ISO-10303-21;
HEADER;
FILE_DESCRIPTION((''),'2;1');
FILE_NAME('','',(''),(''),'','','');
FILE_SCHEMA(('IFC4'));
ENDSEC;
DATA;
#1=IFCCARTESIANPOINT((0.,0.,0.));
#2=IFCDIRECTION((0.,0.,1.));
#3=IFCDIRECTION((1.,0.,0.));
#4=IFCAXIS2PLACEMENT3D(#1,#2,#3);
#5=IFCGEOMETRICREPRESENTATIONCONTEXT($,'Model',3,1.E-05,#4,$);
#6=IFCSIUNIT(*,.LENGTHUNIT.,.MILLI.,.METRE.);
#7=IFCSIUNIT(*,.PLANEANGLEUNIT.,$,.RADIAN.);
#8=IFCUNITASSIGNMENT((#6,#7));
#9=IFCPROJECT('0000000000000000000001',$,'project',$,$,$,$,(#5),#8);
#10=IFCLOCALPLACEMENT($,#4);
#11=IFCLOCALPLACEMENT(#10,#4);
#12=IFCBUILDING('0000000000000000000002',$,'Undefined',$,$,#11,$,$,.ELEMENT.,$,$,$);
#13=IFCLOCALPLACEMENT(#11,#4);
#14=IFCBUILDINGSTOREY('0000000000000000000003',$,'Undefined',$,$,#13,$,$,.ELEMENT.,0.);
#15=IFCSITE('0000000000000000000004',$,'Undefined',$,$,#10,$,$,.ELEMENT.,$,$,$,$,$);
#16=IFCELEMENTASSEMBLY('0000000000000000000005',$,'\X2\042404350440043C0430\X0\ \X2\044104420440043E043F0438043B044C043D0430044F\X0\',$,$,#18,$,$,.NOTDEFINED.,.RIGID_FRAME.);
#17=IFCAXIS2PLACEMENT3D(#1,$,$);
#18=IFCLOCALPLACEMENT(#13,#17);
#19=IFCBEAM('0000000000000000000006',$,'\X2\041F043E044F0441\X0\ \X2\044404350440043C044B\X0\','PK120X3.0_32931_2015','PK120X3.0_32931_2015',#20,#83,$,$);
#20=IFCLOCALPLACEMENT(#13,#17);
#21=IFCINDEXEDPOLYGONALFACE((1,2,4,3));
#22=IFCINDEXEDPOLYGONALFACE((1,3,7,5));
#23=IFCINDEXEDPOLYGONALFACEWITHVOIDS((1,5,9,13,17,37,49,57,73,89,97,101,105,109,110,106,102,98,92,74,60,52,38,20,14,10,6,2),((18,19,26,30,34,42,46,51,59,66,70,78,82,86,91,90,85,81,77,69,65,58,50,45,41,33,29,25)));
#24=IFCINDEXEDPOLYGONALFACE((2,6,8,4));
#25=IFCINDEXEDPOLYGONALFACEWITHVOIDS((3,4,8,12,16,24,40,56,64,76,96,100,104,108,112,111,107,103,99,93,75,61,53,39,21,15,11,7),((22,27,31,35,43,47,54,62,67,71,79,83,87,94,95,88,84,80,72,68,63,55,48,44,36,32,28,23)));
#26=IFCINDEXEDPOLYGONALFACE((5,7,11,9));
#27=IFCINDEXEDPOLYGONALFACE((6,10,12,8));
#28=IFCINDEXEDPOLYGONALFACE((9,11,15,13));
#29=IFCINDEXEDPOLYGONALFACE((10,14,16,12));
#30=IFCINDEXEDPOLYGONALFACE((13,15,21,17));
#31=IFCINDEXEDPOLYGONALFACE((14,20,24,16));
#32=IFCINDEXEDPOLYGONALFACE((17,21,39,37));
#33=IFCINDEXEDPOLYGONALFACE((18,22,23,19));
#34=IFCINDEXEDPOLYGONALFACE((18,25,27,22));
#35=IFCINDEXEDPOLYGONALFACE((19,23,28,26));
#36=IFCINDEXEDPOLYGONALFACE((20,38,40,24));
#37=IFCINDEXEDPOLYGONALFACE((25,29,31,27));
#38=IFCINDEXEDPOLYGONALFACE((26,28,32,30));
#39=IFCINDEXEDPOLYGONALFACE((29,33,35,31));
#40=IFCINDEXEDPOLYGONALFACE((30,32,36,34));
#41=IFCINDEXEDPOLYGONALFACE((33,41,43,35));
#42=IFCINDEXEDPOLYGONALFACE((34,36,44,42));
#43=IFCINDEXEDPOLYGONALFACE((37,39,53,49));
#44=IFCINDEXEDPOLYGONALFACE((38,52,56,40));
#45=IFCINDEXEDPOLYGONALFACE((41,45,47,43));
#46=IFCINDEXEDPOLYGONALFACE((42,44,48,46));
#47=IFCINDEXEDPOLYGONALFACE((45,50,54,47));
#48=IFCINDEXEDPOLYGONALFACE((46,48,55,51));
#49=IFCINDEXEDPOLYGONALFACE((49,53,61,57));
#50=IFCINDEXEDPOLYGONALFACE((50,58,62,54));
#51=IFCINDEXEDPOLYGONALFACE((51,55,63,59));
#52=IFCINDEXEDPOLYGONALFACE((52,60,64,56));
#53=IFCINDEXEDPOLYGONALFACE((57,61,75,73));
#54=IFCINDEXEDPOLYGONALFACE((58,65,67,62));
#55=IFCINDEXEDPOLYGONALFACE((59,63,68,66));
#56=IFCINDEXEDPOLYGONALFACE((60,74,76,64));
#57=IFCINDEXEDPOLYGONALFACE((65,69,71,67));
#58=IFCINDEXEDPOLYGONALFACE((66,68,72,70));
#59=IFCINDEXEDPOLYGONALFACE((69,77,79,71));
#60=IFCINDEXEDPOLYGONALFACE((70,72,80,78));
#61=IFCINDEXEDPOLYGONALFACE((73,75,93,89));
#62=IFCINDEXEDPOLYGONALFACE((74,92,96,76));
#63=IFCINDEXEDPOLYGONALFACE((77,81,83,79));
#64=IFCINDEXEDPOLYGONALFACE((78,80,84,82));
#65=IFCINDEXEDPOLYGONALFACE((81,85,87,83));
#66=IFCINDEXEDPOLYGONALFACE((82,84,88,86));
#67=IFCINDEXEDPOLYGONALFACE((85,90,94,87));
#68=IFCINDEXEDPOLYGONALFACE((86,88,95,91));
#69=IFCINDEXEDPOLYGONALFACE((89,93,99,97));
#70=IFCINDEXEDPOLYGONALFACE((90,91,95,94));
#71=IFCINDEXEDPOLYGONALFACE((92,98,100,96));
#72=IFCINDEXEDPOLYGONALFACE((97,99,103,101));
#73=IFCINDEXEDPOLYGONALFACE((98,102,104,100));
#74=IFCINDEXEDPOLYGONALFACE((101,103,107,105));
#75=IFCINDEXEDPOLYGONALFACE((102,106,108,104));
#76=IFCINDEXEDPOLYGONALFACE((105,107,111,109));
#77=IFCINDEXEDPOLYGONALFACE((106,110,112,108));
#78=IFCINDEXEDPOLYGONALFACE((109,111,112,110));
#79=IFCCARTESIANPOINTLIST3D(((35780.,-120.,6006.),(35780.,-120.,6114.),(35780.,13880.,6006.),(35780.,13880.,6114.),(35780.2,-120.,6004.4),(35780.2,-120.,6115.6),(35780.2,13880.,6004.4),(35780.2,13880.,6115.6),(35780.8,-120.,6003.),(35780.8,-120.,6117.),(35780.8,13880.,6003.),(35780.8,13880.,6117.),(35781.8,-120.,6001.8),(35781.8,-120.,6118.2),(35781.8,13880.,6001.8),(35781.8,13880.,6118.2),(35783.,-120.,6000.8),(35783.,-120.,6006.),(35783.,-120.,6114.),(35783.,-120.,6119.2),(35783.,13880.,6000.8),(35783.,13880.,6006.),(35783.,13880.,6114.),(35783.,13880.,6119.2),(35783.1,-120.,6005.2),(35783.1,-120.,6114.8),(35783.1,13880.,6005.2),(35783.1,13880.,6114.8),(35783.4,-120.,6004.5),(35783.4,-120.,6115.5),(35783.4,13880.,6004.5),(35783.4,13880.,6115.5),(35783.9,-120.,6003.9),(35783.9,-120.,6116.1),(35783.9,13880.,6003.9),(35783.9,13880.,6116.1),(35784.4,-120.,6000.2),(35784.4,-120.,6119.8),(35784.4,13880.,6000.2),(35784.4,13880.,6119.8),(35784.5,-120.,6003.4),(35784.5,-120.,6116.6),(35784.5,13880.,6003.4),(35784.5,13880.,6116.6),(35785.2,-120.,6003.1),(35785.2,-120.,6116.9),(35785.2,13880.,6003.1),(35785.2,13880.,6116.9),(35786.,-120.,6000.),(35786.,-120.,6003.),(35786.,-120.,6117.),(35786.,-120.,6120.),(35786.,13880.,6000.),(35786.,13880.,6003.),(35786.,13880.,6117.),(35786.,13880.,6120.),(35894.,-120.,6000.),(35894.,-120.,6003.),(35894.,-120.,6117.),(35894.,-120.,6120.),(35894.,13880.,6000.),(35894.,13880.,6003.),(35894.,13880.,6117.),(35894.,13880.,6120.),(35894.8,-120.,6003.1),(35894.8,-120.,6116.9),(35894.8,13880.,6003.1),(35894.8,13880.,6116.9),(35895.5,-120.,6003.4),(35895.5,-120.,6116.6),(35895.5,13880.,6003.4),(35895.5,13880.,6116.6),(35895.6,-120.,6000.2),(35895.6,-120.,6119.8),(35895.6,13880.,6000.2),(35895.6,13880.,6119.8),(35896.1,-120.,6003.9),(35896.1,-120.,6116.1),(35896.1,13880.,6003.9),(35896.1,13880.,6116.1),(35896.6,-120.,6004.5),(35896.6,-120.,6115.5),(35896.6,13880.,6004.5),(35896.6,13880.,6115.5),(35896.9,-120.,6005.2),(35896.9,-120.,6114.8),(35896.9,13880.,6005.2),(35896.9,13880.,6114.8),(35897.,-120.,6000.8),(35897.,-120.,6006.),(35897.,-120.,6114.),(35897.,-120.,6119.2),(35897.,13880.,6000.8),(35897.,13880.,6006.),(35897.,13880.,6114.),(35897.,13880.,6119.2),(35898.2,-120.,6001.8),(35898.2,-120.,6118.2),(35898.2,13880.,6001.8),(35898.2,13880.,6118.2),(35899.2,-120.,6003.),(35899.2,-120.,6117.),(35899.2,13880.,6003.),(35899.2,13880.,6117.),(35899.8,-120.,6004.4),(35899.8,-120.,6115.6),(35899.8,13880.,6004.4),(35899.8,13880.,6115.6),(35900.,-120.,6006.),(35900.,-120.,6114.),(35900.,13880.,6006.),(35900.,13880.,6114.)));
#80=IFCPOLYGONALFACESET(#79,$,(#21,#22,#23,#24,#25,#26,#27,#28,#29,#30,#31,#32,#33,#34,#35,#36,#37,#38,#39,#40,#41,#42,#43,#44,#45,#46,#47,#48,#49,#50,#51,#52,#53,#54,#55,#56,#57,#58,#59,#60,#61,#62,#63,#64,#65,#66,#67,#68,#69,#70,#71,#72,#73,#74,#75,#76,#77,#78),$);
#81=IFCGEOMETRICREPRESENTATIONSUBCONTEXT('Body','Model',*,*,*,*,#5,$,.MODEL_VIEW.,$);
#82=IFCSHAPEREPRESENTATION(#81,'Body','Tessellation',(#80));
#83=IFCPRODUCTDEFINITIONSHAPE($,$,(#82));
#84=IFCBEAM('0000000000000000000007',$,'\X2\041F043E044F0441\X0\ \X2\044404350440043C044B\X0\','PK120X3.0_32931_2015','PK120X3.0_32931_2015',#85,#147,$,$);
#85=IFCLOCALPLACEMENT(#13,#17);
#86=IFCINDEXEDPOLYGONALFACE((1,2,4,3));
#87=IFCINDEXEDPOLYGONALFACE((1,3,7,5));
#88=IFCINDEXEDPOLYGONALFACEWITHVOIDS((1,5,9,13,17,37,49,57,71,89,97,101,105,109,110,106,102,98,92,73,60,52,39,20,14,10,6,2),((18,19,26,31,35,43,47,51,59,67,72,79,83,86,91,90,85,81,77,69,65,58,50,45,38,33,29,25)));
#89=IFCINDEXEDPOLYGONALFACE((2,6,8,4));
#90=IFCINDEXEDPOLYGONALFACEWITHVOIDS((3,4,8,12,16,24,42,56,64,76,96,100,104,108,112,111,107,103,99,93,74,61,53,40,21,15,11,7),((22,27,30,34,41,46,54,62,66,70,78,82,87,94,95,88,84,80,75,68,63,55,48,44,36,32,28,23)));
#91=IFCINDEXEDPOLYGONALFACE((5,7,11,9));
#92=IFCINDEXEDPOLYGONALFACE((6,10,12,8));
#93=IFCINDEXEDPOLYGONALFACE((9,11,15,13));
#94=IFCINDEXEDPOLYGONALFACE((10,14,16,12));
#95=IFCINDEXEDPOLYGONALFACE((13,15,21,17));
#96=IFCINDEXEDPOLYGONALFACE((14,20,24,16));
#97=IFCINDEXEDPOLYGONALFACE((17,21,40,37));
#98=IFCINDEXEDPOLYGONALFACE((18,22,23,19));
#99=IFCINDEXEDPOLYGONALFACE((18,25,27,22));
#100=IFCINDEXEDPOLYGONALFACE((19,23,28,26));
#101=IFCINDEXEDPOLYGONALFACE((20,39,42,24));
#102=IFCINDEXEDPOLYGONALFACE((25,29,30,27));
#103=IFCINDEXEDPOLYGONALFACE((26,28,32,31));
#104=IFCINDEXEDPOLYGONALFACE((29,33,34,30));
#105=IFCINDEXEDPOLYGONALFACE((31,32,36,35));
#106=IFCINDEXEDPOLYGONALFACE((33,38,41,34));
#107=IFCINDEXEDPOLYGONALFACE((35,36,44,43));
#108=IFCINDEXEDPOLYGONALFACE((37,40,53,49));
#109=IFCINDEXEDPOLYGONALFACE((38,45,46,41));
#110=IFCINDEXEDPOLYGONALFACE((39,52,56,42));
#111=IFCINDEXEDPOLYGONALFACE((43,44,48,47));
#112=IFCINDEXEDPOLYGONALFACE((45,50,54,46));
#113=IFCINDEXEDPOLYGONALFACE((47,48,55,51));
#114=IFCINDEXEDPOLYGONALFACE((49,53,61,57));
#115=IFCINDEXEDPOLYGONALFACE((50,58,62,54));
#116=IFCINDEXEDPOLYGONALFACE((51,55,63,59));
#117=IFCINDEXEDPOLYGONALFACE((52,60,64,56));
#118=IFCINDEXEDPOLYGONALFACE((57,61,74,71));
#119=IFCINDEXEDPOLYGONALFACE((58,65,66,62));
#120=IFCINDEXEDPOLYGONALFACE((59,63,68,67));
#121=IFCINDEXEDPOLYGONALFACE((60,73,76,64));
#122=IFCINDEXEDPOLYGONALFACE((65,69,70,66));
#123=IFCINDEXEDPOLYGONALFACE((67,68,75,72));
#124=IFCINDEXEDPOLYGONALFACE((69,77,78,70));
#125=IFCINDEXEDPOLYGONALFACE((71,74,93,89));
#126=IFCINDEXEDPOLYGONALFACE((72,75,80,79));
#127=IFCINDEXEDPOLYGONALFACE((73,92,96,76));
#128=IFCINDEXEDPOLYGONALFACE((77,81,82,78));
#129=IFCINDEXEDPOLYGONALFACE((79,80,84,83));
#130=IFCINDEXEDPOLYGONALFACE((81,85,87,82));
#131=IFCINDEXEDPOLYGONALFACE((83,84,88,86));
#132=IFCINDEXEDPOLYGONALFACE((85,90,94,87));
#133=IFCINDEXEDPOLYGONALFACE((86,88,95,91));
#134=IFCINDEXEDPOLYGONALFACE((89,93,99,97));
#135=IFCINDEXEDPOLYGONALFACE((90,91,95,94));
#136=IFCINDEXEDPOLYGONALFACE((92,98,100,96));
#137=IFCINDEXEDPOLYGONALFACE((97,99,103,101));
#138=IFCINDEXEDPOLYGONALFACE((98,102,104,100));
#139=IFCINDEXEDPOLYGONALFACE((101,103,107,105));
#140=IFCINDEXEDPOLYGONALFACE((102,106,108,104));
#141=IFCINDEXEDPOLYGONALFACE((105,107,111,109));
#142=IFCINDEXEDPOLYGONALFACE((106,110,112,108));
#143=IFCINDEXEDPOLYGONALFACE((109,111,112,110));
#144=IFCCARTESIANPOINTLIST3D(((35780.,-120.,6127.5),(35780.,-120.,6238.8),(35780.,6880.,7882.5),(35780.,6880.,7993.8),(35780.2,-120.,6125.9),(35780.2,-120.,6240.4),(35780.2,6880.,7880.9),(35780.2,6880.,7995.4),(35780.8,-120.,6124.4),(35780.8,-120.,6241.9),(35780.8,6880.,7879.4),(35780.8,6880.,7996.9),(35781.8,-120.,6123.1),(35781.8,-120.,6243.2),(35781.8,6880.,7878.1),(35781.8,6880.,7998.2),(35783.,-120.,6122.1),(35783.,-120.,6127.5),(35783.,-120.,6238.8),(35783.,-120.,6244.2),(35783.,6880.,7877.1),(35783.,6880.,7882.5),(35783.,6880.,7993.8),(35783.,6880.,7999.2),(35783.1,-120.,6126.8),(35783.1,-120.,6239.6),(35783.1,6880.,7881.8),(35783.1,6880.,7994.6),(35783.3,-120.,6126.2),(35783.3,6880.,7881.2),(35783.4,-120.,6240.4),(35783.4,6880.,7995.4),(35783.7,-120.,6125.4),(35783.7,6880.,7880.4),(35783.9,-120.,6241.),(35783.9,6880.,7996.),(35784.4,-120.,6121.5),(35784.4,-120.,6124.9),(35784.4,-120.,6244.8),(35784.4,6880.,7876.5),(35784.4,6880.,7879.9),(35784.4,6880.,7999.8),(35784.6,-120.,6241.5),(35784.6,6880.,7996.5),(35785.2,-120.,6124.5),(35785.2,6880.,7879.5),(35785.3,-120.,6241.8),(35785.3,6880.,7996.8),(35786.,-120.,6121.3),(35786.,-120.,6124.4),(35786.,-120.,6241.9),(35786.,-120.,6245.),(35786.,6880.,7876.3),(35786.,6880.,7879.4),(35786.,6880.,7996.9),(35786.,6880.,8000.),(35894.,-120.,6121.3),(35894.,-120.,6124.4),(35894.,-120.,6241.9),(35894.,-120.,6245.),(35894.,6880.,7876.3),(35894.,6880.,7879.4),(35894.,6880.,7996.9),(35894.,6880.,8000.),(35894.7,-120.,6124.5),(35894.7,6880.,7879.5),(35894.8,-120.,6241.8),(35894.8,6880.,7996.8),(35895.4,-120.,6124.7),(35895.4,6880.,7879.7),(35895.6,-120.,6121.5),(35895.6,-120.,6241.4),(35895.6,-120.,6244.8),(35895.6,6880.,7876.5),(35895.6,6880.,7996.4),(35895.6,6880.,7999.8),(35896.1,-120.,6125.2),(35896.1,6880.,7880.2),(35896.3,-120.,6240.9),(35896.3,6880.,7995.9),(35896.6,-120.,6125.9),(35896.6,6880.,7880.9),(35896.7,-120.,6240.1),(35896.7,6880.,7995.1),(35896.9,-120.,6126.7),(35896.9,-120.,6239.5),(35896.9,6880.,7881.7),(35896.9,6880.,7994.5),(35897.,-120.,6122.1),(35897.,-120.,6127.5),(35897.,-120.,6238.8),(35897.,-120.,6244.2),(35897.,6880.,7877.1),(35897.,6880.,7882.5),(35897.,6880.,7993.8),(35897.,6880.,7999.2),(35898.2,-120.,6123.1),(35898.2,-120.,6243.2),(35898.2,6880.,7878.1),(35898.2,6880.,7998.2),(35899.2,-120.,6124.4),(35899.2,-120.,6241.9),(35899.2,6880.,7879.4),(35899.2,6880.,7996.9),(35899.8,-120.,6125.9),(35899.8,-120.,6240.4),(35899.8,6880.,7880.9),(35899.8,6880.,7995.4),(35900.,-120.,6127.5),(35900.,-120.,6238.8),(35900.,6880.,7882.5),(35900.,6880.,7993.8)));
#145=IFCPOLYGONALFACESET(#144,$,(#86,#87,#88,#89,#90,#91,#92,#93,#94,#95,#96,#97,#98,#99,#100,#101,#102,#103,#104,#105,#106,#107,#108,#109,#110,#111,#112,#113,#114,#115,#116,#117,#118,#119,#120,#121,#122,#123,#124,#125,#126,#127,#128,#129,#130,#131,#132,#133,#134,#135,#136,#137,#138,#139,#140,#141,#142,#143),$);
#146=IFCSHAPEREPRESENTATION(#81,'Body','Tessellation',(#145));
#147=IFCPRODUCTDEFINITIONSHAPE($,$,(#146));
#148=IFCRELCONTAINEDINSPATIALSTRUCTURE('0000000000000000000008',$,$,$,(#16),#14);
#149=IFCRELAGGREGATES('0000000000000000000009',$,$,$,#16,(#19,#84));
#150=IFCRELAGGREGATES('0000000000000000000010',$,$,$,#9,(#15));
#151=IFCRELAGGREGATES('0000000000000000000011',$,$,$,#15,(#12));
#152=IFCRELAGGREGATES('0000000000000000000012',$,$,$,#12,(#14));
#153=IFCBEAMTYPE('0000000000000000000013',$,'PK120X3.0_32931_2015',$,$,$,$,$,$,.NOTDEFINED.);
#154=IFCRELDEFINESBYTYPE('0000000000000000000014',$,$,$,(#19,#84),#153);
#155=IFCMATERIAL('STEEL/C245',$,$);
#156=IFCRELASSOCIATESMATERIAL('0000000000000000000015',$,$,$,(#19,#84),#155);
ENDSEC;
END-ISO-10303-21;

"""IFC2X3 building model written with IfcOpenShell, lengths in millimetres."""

from ifc_helpers import new_model, si_unit, frame, origin_with_axes, origin_2d_with_axis, place, context, subcontext, project, spatial, hollow_rectangle, extrude, clip, halfspace, material, type_object, element, aggregate, save


model = new_model("IFC2X3")

# Units and contexts
model_context = context("Model", 3, precision=1e-05, world=origin_with_axes())
body_context = subcontext(model_context, "Body", "Model", "MODEL_VIEW")
ifc_project = project(units=[si_unit("LENGTHUNIT", "METRE", prefix="MILLI"), si_unit("PLANEANGLEUNIT", "RADIAN")], contexts=[model_context])

# Site, building, storey
site_placement = place(None, origin_with_axes())
site = spatial("IfcSite", under=ifc_project, at=site_placement, Name="Undefined", CompositionType="ELEMENT")
building_placement = place(site_placement, origin_with_axes())
building = spatial("IfcBuilding", under=site, at=building_placement, Name="Undefined", CompositionType="ELEMENT")
storey_placement = place(building_placement, origin_with_axes())
storey = spatial("IfcBuildingStorey", under=building, at=storey_placement, Name="Undefined", CompositionType="ELEMENT", Elevation=0.0)

# Shared definitions
ifc_material = material(Name="STEEL/C245")

# Element assembly
assembly_1_placement = place(storey_placement, origin_with_axes())
assembly_1 = element("IfcElementAssembly", 1, at=assembly_1_placement, inside=storey, Name="Ферма стропильная", AssemblyPlace="NOTDEFINED", PredefinedType="RIGID_FRAME")

# Beams
beam_type_1 = type_object("IfcBeamType", Name="PK120X3.0_32931_2015", PredefinedType="NOTDEFINED")
beam_1_placement = place(assembly_1_placement, frame((35840.0, -120.0, 6060.0), z_axis=(0.0, 0.0, 1.0), x_axis=(0.0, 1.0, 0.0)))
beam_1 = element("IfcBeam", 2, at=beam_1_placement, type_object=beam_type_1, material=ifc_material, Name="Пояс фермы", Description="PK120X3.0_32931_2015", ObjectType="PK120X3.0_32931_2015", context=body_context, shape_type="SweptSolid", body=[
    extrude(hollow_rectangle(XDim=120.0, YDim=120.0, WallThickness=3.0, InnerFilletRadius=3.0, OuterFilletRadius=6.0, at=origin_2d_with_axis()), frame((14000.0, 0.0, 0.0), z_axis=(-1.0, 0.0, 0.0), x_axis=(0.0, -1.0, 0.0)), (0.0, 0.0, 1.0), 14000.0),
])
beam_2_placement = place(assembly_1_placement, frame((35840.0, -105.4, 6186.8), z_axis=(0.0, -0.243188, 0.969979), x_axis=(0.0, 0.969979, 0.243188)))
beam_2 = element("IfcBeam", 3, at=beam_2_placement, type_object=beam_type_1, material=ifc_material, Name="Пояс фермы", Description="PK120X3.0_32931_2015", ObjectType="PK120X3.0_32931_2015", context=body_context, shape_type="Clipping", body=[
    clip(clip(extrude(hollow_rectangle(XDim=120.0, YDim=120.0, WallThickness=3.0, InnerFilletRadius=3.0, OuterFilletRadius=6.0, at=origin_2d_with_axis()), frame((7232.0, 0.0, 0.0), z_axis=(-1.0, 0.0, 0.0), x_axis=(0.0, -1.0, 0.0)), (0.0, 0.0, 1.0), 7277.4), halfspace(frame((7216.6, 0.0, 60.0), z_axis=(0.969979, 0.0, -0.243188), x_axis=(0.0, -1.0, 0.0)), False)), halfspace(frame((0.0, 0.0, 60.0), z_axis=(0.969979, 0.0, -0.243188), x_axis=(0.0, -1.0, 0.0)), True)),
])
aggregate(assembly_1, [beam_1, beam_2])

save(model, "model.ifc")
